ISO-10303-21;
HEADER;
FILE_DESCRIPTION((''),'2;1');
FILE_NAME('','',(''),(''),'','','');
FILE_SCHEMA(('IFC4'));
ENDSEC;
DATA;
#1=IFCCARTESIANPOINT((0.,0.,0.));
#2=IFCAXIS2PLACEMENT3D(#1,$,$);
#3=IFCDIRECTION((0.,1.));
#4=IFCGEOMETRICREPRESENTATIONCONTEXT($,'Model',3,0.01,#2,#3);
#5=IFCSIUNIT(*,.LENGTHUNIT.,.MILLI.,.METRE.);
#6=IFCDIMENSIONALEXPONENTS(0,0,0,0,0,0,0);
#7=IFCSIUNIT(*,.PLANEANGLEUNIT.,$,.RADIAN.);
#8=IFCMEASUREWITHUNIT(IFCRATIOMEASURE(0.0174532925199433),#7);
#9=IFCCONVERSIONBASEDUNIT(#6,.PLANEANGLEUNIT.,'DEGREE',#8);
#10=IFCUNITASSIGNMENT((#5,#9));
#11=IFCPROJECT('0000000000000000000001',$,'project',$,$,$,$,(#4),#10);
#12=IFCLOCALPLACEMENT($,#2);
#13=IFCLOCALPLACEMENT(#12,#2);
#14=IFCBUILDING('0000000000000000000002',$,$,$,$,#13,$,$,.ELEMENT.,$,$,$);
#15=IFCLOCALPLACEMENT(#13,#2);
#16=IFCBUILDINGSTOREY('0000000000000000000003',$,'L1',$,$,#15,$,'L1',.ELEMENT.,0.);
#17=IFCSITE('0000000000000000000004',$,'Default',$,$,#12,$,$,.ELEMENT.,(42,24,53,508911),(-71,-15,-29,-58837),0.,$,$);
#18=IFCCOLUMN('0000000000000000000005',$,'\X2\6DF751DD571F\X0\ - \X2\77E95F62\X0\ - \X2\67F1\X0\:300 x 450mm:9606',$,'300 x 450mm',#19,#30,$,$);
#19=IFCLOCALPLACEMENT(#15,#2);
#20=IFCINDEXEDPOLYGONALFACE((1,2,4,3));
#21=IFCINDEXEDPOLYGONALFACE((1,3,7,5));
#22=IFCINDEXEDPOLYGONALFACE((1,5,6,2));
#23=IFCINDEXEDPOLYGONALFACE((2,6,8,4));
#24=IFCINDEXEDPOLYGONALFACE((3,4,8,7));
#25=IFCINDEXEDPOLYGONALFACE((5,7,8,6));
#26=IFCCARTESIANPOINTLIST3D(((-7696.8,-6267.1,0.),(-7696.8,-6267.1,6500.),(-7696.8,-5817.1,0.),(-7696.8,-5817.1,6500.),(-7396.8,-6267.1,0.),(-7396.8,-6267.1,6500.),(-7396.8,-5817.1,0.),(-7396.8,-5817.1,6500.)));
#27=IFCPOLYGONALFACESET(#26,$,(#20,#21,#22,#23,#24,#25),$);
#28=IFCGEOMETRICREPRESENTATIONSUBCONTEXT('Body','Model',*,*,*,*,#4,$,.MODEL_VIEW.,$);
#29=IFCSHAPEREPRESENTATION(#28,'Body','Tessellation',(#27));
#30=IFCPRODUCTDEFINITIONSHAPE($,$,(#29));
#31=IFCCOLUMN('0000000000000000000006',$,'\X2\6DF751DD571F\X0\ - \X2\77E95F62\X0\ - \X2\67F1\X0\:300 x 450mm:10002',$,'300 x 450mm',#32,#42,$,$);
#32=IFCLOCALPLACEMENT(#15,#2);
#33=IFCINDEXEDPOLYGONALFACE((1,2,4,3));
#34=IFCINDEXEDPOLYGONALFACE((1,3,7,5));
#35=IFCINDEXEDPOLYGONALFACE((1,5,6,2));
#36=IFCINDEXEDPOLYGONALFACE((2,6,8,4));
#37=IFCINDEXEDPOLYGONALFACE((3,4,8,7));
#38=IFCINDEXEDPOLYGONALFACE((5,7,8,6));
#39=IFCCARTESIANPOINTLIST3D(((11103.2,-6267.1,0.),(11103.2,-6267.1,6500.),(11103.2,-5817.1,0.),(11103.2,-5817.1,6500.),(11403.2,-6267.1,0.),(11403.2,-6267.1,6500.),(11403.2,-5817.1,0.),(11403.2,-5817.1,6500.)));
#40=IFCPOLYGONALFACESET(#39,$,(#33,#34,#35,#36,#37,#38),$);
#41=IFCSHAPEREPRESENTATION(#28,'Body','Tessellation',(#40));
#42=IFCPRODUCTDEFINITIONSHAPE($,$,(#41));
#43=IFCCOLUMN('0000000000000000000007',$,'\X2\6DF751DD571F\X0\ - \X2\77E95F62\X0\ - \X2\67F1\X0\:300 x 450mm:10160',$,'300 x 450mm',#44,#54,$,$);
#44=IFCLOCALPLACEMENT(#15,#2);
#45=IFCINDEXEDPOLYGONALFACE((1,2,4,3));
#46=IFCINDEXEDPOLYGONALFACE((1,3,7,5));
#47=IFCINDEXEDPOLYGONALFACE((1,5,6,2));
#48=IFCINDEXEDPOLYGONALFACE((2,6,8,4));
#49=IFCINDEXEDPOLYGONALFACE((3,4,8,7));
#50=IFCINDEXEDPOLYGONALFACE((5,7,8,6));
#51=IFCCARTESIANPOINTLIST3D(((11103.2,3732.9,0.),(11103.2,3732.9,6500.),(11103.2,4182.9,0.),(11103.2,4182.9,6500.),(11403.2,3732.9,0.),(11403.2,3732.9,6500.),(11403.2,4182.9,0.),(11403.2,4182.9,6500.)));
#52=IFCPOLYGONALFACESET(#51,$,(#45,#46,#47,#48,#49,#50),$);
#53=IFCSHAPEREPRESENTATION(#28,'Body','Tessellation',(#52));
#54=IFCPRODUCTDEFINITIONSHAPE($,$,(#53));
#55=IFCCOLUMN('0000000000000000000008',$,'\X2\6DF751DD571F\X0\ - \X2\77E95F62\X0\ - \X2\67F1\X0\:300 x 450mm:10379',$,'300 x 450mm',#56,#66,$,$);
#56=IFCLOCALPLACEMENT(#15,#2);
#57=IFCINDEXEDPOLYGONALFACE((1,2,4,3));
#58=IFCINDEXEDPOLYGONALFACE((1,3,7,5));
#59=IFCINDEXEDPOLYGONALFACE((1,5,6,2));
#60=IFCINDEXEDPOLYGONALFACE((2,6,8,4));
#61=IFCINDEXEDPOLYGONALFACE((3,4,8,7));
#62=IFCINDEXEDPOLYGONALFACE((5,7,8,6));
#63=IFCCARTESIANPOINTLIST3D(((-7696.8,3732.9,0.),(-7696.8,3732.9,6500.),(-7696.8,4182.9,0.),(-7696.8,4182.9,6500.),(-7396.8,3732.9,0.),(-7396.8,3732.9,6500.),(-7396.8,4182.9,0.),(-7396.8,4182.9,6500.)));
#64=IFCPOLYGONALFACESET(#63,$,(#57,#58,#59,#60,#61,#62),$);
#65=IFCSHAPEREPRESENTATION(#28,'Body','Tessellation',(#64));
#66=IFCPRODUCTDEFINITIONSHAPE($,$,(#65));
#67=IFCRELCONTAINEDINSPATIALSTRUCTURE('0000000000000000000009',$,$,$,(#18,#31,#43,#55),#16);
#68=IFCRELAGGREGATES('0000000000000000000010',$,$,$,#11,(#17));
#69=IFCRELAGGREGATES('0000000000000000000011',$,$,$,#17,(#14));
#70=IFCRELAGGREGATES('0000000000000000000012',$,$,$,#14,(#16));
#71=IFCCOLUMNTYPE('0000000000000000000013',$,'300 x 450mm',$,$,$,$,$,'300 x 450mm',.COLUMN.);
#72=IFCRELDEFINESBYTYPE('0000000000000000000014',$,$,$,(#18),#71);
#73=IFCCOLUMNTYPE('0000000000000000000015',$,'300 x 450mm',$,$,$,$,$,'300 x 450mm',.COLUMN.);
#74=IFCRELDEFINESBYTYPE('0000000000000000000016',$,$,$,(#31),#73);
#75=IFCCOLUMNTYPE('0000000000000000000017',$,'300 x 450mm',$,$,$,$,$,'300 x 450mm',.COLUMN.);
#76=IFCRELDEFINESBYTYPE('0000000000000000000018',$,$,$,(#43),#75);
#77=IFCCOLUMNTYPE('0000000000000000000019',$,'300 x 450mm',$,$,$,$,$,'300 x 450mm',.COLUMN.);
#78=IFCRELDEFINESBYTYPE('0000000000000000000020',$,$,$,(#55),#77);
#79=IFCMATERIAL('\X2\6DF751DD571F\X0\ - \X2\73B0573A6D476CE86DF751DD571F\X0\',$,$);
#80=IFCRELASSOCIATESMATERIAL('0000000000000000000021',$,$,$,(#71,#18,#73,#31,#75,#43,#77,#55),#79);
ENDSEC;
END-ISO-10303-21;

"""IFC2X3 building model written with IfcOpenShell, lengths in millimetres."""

from ifc_helpers import new_model, entity, si_unit, converted_unit, direction, frame, frame_2d, origin, origin_2d_with_axis, place, context, subcontext, project, spatial, rectangle, extrude, source, transform, mapped, material, type_object, type_shapes, element, save


model = new_model("IFC2X3")

# Units and contexts
model_context = context("Model", 3, precision=0.01, world=origin(), true_north=direction((0.0, 1.0)))
body_context = subcontext(model_context, "Body", "Model", "MODEL_VIEW")
ifc_project = project(units=[si_unit("LENGTHUNIT", "METRE", prefix="MILLI"), converted_unit("PLANEANGLEUNIT", "DEGREE", entity("IfcRatioMeasure", 0.0174532925199433), si_unit("PLANEANGLEUNIT", "RADIAN"), dimensions=[0, 0, 0, 0, 0, 0, 0])], contexts=[model_context])

# Site, building, storey
site_placement = place(None, origin())
site = spatial("IfcSite", under=ifc_project, at=site_placement, Name="Default", CompositionType="ELEMENT", RefLatitude=(42, 24, 53, 508911), RefLongitude=(-71, -15, -29, -58837), RefElevation=0.0)
building_placement = place(site_placement, origin())
building = spatial("IfcBuilding", under=site, at=building_placement, CompositionType="ELEMENT")
storey_placement = place(building_placement, origin())
storey = spatial("IfcBuildingStorey", under=building, at=storey_placement, Name="L1", LongName="L1", CompositionType="ELEMENT", Elevation=0.0)

# Columns
ifc_material = material(Name="混凝土 - 现场浇注混凝土")
column_type_1 = type_object("IfcColumnType", Name="300 x 450mm", ElementType="300 x 450mm", PredefinedType="COLUMN", material=ifc_material)
shared_shape_1 = source(origin(), body_context, "Body", "SweptSolid", [
    extrude(rectangle(XDim=450.0, YDim=300.0, at=frame_2d((0.0, 0.0), x_axis=(1.0, 0.0))), frame((-7546.8, -6042.1, 0.0), z_axis=(0.0, 0.0, 1.0), x_axis=(0.0, -1.0, 0.0)), (0.0, 0.0, 1.0), 6500.0),
])
type_shapes(column_type_1, [shared_shape_1])
column_1_placement = place(storey_placement, origin())
element("IfcColumn", 1, at=column_1_placement, inside=storey, type_object=column_type_1, material=ifc_material, Name="混凝土 - 矩形 - 柱:300 x 450mm:9606", ObjectType="300 x 450mm", context=body_context, shape_type="MappedRepresentation", body=[
    mapped(shared_shape_1, transform((0.0, 0.0, 0.0), scale=1.0)),
])
column_type_2 = type_object("IfcColumnType", Name="300 x 450mm", ElementType="300 x 450mm", PredefinedType="COLUMN", material=ifc_material)
shared_shape_2 = source(origin(), body_context, "Body", "SweptSolid", [
    extrude(rectangle(XDim=450.0, YDim=300.0, at=origin_2d_with_axis()), frame((11253.2, -6042.1, 0.0), z_axis=(0.0, 0.0, 1.0), x_axis=(0.0, -1.0, 0.0)), (0.0, 0.0, 1.0), 6500.0),
])
type_shapes(column_type_2, [shared_shape_2])
column_2_placement = place(storey_placement, origin())
element("IfcColumn", 2, at=column_2_placement, inside=storey, type_object=column_type_2, material=ifc_material, Name="混凝土 - 矩形 - 柱:300 x 450mm:10002", ObjectType="300 x 450mm", context=body_context, shape_type="MappedRepresentation", body=[
    mapped(shared_shape_2, transform((0.0, 0.0, 0.0), scale=1.0)),
])
column_type_3 = type_object("IfcColumnType", Name="300 x 450mm", ElementType="300 x 450mm", PredefinedType="COLUMN", material=ifc_material)
shared_shape_3 = source(origin(), body_context, "Body", "SweptSolid", [
    extrude(rectangle(XDim=450.0, YDim=300.0, at=frame_2d((0.0, 0.0), x_axis=(1.0, 0.0))), frame((11253.2, 3957.9, 0.0), z_axis=(0.0, 0.0, 1.0), x_axis=(0.0, -1.0, 0.0)), (0.0, 0.0, 1.0), 6500.0),
])
type_shapes(column_type_3, [shared_shape_3])
column_3_placement = place(storey_placement, origin())
element("IfcColumn", 3, at=column_3_placement, inside=storey, type_object=column_type_3, material=ifc_material, Name="混凝土 - 矩形 - 柱:300 x 450mm:10160", ObjectType="300 x 450mm", context=body_context, shape_type="MappedRepresentation", body=[
    mapped(shared_shape_3, transform((0.0, 0.0, 0.0), scale=1.0)),
])
column_type_4 = type_object("IfcColumnType", Name="300 x 450mm", ElementType="300 x 450mm", PredefinedType="COLUMN", material=ifc_material)
shared_shape_4 = source(origin(), body_context, "Body", "SweptSolid", [
    extrude(rectangle(XDim=450.0, YDim=300.0, at=frame_2d((0.0, 0.0), x_axis=(1.0, 0.0))), frame((-7546.8, 3957.9, 0.0), z_axis=(0.0, 0.0, 1.0), x_axis=(0.0, -1.0, 0.0)), (0.0, 0.0, 1.0), 6500.0),
])
type_shapes(column_type_4, [shared_shape_4])
column_4_placement = place(storey_placement, origin())
element("IfcColumn", 4, at=column_4_placement, inside=storey, type_object=column_type_4, material=ifc_material, Name="混凝土 - 矩形 - 柱:300 x 450mm:10379", ObjectType="300 x 450mm", context=body_context, shape_type="MappedRepresentation", body=[
    mapped(shared_shape_4, transform((0.0, 0.0, 0.0), scale=1.0)),
])

save(model, "model.ifc")
